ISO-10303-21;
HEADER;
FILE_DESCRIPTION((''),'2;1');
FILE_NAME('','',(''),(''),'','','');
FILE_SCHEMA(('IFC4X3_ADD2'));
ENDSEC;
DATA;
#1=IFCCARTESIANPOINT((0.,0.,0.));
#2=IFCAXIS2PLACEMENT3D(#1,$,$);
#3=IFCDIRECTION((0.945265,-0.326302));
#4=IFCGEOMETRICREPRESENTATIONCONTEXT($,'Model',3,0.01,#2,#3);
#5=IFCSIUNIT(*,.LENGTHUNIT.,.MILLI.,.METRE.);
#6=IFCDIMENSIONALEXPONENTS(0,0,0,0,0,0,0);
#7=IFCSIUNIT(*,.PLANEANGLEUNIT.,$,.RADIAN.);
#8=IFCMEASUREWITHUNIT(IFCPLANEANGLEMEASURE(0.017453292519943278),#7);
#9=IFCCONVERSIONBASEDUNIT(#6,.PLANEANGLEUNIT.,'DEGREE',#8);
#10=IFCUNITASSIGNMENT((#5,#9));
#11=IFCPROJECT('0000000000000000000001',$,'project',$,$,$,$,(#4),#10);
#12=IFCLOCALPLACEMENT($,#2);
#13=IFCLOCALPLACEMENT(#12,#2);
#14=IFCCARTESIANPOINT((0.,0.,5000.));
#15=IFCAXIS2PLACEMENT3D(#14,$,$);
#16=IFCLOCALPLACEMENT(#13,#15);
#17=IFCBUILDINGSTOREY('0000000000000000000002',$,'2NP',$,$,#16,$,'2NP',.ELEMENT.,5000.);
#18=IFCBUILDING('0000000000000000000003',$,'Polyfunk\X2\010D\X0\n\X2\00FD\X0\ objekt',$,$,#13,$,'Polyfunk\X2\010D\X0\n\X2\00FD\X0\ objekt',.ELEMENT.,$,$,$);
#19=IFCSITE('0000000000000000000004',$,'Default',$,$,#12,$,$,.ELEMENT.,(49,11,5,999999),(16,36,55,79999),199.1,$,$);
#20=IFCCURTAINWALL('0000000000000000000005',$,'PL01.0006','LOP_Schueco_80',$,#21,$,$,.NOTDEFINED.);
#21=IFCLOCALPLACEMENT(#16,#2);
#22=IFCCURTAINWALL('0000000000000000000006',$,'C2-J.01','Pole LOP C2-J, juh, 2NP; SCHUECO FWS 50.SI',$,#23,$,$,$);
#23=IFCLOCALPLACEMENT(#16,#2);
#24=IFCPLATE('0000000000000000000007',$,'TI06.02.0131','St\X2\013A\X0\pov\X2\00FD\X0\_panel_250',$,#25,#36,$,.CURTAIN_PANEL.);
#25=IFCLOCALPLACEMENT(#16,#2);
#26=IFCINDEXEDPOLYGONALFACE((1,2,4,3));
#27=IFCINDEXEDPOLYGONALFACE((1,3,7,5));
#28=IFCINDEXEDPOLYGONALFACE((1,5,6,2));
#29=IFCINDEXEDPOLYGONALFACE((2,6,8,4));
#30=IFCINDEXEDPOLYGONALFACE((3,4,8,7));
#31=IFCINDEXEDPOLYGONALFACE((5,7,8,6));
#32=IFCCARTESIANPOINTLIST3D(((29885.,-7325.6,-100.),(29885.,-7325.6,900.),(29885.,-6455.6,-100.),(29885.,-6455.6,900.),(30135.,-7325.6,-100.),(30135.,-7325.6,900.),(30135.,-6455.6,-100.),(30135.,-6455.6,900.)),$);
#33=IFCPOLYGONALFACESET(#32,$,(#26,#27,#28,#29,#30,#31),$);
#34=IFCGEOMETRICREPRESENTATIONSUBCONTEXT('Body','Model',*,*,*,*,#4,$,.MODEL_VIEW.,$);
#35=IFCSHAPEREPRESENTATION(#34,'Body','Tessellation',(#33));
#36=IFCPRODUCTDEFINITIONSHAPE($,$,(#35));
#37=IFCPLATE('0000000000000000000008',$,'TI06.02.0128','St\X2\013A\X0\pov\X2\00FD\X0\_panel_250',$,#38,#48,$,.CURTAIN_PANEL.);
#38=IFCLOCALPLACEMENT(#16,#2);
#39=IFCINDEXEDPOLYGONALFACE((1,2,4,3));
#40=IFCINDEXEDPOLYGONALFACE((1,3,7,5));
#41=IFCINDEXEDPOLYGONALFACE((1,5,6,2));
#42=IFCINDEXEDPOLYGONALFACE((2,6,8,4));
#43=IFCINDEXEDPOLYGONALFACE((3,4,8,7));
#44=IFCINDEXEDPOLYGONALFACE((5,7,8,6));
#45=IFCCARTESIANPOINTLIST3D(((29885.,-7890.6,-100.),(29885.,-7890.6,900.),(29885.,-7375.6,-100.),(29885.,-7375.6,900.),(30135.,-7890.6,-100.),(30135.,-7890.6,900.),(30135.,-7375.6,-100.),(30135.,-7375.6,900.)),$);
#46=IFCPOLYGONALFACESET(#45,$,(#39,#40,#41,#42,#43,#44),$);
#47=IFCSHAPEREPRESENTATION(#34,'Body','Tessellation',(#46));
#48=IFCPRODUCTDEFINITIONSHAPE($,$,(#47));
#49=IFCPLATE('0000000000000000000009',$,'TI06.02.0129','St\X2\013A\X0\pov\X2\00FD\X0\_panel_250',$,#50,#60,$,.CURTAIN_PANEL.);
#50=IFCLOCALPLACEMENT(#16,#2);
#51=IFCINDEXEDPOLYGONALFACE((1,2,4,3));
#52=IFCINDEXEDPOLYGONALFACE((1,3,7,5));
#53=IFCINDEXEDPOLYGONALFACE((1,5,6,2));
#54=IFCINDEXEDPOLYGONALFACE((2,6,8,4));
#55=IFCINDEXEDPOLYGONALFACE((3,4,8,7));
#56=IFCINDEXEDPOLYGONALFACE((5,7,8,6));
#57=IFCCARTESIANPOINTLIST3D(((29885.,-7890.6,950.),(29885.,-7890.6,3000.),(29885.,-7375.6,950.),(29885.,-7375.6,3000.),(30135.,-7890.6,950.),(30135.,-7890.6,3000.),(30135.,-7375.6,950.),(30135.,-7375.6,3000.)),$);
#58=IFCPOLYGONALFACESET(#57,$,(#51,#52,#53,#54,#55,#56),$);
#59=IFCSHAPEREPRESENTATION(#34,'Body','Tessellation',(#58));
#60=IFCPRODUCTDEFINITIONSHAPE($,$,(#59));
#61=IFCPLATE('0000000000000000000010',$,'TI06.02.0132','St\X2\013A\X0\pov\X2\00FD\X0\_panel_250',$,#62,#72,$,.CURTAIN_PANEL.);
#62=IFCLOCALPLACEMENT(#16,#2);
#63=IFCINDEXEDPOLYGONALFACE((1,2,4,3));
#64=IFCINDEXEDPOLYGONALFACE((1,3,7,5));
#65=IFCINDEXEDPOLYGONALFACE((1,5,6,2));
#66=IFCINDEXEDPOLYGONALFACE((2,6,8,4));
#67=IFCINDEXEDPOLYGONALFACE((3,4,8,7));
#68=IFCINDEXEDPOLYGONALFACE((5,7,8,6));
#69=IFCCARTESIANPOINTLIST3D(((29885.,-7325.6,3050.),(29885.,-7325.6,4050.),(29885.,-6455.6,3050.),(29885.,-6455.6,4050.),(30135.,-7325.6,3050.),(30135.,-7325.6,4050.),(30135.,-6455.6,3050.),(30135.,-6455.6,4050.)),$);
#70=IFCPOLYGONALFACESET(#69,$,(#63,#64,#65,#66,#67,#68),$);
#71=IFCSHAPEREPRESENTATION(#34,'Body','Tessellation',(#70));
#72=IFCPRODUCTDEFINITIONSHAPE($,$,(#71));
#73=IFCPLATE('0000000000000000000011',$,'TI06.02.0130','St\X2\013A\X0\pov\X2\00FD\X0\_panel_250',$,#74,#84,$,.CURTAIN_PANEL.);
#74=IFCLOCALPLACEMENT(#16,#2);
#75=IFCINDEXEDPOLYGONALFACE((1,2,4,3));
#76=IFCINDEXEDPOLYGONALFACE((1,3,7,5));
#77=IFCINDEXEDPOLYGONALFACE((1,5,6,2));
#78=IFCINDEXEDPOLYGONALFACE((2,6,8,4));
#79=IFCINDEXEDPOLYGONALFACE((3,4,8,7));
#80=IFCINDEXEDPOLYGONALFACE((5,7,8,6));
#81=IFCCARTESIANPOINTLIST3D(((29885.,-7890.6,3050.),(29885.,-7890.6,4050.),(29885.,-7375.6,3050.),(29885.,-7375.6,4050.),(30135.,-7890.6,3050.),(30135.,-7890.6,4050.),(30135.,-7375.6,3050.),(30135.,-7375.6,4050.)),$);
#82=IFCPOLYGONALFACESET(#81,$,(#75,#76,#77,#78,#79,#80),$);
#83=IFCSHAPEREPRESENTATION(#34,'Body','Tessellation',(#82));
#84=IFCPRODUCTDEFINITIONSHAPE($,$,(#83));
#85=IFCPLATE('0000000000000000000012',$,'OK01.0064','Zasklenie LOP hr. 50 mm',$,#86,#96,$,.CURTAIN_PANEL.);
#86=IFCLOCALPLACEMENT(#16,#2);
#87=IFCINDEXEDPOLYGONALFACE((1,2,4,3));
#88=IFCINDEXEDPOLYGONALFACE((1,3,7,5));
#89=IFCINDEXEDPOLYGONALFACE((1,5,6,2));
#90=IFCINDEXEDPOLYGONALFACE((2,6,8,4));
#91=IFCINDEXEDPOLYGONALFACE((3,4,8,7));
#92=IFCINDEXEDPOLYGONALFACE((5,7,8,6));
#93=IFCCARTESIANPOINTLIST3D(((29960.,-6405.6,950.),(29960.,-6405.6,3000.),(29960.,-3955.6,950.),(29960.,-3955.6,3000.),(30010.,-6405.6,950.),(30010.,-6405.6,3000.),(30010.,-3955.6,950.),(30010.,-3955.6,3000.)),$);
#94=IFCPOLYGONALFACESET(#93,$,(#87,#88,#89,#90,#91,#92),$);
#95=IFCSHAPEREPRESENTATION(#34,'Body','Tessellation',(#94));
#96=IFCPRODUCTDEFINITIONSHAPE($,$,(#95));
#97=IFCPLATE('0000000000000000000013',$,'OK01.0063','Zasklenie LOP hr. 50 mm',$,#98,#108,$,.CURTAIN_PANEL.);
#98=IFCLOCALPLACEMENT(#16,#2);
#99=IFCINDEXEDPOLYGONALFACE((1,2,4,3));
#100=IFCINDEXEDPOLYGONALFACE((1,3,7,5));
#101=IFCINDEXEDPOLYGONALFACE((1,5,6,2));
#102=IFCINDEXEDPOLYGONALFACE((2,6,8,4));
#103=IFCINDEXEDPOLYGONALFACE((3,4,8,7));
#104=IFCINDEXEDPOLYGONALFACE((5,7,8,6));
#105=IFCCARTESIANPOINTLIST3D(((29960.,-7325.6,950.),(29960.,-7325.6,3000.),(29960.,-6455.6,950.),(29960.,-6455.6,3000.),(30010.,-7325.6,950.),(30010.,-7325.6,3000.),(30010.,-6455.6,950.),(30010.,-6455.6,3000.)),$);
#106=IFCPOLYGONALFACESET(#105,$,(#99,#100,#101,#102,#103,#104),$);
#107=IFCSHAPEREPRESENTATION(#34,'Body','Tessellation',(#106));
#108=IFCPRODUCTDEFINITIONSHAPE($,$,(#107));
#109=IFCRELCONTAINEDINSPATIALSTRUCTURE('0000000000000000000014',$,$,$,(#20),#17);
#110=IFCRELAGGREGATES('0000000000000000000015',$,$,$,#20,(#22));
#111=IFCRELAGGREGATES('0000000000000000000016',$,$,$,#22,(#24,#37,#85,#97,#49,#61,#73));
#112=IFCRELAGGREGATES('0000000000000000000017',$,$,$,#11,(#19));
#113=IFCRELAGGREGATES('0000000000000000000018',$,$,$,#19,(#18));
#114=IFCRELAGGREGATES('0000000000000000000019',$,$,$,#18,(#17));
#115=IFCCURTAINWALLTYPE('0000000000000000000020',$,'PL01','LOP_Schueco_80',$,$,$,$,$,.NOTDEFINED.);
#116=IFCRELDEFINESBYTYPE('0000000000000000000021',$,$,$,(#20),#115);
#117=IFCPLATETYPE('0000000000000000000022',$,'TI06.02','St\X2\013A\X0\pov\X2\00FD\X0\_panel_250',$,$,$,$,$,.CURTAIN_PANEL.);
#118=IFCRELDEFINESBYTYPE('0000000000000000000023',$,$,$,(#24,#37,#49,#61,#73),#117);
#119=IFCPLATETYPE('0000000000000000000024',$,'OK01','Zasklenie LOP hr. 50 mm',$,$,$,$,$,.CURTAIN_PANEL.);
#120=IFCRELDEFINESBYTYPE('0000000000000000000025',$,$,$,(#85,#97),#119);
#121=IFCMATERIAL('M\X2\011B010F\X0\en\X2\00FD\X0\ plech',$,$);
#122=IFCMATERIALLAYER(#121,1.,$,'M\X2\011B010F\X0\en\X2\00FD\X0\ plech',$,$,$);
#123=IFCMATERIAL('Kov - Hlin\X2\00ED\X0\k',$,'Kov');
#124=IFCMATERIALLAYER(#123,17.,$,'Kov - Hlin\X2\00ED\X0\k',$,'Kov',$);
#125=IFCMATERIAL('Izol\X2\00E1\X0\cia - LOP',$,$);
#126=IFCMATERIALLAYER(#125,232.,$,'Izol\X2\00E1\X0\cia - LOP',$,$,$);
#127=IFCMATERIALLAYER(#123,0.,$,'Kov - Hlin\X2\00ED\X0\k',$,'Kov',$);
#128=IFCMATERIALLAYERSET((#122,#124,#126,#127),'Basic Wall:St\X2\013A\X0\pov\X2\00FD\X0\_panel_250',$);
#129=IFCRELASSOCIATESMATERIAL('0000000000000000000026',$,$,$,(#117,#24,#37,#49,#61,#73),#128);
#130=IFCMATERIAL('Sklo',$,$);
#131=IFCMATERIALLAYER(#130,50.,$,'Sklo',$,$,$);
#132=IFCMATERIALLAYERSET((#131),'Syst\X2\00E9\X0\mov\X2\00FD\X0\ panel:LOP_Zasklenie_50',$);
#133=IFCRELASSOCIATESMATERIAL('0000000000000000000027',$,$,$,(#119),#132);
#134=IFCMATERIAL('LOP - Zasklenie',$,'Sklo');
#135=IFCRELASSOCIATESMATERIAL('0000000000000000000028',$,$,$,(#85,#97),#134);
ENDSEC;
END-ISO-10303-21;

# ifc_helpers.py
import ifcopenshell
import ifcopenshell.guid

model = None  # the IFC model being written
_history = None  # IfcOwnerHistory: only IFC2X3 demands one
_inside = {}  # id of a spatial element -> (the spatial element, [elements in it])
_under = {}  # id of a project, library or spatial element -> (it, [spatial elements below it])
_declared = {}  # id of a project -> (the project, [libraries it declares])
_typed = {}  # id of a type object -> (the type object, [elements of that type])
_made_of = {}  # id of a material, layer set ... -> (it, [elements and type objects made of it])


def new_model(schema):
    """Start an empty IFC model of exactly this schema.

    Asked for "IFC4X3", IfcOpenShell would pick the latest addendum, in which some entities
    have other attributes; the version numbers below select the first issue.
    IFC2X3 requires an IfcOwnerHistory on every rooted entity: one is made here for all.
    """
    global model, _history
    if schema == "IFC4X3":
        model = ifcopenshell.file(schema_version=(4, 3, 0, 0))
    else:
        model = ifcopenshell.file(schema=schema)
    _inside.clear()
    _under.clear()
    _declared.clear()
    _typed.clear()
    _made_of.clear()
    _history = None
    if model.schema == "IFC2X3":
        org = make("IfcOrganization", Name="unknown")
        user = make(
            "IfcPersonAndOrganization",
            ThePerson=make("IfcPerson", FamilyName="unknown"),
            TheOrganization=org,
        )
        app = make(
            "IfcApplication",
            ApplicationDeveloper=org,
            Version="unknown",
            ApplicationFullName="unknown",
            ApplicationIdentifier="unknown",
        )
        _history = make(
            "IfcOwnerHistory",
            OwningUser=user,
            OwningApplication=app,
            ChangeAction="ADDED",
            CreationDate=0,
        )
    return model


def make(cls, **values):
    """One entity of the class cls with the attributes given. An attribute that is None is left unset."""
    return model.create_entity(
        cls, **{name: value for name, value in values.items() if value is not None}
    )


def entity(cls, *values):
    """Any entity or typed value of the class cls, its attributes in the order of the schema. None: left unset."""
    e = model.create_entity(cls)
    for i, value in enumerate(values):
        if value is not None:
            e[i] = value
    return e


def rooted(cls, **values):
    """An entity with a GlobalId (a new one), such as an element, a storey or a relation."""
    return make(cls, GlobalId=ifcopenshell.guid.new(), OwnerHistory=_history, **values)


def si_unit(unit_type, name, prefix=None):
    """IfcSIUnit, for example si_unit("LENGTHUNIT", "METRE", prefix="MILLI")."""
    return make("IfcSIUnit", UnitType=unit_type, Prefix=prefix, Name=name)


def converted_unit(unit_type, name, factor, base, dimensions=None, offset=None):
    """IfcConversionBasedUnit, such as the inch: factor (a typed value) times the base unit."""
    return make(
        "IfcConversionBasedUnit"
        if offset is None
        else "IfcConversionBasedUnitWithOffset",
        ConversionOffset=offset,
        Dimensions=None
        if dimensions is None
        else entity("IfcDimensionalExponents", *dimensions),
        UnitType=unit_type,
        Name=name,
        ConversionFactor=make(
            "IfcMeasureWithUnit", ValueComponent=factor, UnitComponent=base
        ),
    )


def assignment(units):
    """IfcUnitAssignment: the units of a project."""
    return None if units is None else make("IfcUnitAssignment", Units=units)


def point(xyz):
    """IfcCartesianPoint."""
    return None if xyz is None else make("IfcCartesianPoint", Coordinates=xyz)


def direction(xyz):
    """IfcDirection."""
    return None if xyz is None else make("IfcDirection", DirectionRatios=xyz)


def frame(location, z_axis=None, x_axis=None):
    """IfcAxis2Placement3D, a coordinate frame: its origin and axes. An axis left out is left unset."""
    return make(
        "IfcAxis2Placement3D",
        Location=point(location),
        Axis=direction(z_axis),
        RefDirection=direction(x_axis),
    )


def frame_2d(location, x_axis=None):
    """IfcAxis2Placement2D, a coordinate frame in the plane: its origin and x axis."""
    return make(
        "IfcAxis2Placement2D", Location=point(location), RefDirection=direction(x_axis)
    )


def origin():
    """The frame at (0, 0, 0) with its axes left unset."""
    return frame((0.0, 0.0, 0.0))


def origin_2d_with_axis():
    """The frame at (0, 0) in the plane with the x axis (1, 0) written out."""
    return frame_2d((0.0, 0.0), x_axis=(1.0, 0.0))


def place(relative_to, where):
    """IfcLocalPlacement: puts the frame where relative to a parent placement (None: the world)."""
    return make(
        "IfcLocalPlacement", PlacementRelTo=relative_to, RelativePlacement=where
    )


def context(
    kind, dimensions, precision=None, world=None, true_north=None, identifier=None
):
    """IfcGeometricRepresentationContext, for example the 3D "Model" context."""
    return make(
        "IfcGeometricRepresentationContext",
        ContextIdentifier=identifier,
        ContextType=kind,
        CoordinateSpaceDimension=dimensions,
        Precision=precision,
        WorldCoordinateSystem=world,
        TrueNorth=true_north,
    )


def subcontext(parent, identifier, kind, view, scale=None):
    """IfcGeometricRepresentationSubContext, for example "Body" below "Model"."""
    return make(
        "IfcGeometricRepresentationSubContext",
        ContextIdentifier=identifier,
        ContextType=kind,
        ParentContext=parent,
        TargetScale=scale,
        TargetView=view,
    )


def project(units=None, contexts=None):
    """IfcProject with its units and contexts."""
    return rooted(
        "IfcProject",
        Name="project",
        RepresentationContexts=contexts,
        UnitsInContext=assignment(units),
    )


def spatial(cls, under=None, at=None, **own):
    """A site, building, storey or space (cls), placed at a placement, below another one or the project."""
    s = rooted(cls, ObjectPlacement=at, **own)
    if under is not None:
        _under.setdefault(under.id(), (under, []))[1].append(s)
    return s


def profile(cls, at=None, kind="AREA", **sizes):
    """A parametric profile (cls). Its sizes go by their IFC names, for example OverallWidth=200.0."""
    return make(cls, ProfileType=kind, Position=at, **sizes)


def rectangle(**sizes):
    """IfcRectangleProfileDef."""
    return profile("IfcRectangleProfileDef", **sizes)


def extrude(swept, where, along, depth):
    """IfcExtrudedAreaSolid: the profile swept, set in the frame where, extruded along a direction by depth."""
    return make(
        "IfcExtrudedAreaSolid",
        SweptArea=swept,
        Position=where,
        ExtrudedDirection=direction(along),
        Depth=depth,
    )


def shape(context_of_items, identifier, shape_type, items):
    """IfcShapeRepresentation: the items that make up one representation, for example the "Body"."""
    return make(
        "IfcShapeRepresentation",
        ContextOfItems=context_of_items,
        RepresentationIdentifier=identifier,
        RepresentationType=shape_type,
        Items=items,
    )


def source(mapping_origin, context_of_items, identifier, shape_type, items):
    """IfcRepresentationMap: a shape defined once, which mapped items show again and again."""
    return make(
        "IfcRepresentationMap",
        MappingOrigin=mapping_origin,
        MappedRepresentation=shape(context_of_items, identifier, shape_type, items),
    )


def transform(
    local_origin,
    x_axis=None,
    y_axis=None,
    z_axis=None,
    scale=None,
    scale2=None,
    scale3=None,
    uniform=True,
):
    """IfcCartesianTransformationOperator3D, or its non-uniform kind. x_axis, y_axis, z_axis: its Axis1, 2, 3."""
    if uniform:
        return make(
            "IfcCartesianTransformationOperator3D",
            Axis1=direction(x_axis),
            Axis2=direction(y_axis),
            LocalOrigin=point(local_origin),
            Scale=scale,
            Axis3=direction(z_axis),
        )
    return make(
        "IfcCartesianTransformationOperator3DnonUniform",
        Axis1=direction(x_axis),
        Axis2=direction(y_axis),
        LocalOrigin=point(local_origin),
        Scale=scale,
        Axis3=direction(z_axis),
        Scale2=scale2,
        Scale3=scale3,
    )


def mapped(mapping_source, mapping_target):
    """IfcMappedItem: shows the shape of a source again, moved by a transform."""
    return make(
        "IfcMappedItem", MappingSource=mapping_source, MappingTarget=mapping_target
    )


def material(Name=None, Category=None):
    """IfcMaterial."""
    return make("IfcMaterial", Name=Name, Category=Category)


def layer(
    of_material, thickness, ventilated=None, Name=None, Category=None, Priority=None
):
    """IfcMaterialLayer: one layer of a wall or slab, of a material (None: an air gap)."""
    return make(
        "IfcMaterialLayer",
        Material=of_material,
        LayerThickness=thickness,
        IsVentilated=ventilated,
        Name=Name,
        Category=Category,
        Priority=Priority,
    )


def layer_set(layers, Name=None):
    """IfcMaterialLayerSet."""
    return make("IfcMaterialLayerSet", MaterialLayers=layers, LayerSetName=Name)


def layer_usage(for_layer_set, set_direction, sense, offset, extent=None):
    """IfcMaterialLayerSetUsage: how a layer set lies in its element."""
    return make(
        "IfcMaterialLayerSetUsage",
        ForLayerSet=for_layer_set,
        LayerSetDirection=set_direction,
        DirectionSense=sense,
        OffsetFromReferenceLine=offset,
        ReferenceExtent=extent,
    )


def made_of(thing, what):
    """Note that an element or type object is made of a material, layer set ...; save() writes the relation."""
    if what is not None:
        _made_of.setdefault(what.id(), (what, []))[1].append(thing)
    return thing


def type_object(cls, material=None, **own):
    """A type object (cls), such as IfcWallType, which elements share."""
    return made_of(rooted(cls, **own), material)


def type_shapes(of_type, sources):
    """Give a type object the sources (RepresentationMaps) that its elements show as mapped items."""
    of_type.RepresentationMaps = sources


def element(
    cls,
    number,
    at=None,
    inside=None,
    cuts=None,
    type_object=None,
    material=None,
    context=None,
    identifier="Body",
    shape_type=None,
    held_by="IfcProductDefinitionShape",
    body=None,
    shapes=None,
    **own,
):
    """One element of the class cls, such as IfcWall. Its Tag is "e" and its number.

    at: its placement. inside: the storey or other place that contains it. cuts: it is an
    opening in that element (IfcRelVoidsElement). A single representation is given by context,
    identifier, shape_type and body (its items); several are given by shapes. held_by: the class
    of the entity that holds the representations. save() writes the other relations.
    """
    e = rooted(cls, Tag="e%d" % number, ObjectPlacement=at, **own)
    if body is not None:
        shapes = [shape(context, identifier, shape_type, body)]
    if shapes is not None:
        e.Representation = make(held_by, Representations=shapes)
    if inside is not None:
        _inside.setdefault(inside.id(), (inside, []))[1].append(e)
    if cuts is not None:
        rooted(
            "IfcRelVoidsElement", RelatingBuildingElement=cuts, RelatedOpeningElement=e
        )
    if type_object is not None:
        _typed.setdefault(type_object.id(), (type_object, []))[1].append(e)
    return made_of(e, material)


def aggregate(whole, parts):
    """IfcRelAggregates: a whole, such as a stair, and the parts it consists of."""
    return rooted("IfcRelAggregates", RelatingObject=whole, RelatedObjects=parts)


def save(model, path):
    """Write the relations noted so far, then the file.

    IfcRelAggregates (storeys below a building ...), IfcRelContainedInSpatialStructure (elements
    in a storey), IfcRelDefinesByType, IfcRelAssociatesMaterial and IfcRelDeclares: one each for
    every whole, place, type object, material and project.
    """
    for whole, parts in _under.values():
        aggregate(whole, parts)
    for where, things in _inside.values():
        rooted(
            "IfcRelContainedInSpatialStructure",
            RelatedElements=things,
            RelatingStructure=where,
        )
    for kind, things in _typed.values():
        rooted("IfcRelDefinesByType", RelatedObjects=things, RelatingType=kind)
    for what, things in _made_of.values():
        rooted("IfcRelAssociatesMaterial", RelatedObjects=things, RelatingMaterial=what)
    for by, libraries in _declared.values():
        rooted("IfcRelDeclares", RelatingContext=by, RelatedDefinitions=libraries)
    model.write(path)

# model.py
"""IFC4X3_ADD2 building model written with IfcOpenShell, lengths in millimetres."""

from ifc_helpers import new_model, entity, si_unit, converted_unit, direction, frame, frame_2d, origin, origin_2d_with_axis, place, context, subcontext, project, spatial, rectangle, extrude, source, transform, mapped, material, layer, layer_set, layer_usage, type_object, type_shapes, element, aggregate, save


model = new_model("IFC4X3_ADD2")

# Units and contexts
model_context = context("Model", 3, precision=0.01, world=origin(), true_north=direction((0.945265, -0.326302)))
body_context = subcontext(model_context, "Body", "Model", "MODEL_VIEW")
ifc_project = project(units=[si_unit("LENGTHUNIT", "METRE", prefix="MILLI"), converted_unit("PLANEANGLEUNIT", "DEGREE", entity("IfcPlaneAngleMeasure", 0.017453292519943278), si_unit("PLANEANGLEUNIT", "RADIAN"), dimensions=[0, 0, 0, 0, 0, 0, 0])], contexts=[model_context])

# Site, building, storey
site_placement = place(None, origin())
site = spatial("IfcSite", under=ifc_project, at=site_placement, Name="Default", CompositionType="ELEMENT", RefLatitude=(49, 11, 5, 999999), RefLongitude=(16, 36, 55, 79999), RefElevation=199.1)
building_placement = place(site_placement, origin())
building = spatial("IfcBuilding", under=site, at=building_placement, Name="Polyfunkčný objekt", LongName="Polyfunkčný objekt", CompositionType="ELEMENT")
storey_placement = place(building_placement, frame((0.0, 0.0, 5000.0)))
storey = spatial("IfcBuildingStorey", under=building, at=storey_placement, Name="2NP", LongName="2NP", CompositionType="ELEMENT", Elevation=5000.0)

# Curtain walls, plates
curtain_wall_type = type_object("IfcCurtainWallType", Name="PL01", Description="LOP_Schueco_80", PredefinedType="NOTDEFINED")
curtain_wall_1_placement = place(storey_placement, frame((0.0, 0.0, -5000.0)))
curtain_wall_1 = element("IfcCurtainWall", 1, at=curtain_wall_1_placement, inside=storey, type_object=curtain_wall_type, Name="PL01.0006", Description="LOP_Schueco_80", PredefinedType="NOTDEFINED")
curtain_wall_2 = element("IfcCurtainWall", 2, Name="C2-J.01", Description="Pole LOP C2-J, juh, 2NP; SCHUECO FWS 50.SI")
aggregate(curtain_wall_1, [curtain_wall_2])
ifc_material_1 = material(Name="Měďený plech")
ifc_layer_1 = layer(ifc_material_1, 1.0, Name="Měďený plech")
ifc_material_2 = material(Name="Kov - Hliník", Category="Kov")
ifc_layer_2 = layer(ifc_material_2, 17.0, Name="Kov - Hliník", Category="Kov")
ifc_material_3 = material(Name="Izolácia - LOP")
ifc_layer_3 = layer(ifc_material_3, 232.0, Name="Izolácia - LOP")
ifc_layer_4 = layer(ifc_material_2, 0.0, Name="Kov - Hliník", Category="Kov")
ifc_layer_set_1 = layer_set([ifc_layer_1, ifc_layer_2, ifc_layer_3, ifc_layer_4], Name="Basic Wall:Stĺpový_panel_250")
ifc_layer_usage_1 = layer_usage(ifc_layer_set_1, "AXIS2", "POSITIVE", -125.0)
plate_type_1 = type_object("IfcPlateType", Name="TI06.02", Description="Stĺpový_panel_250", PredefinedType="CURTAIN_PANEL", material=ifc_layer_set_1)
plate_1_placement = place(storey_placement, frame((30010.0, -6455.6, -100.0), z_axis=(0.0, 0.0, 1.0), x_axis=(0.0, -1.0, 0.0)))
plate_1 = element("IfcPlate", 3, at=plate_1_placement, type_object=plate_type_1, material=ifc_layer_usage_1, Name="TI06.02.0131", Description="Stĺpový_panel_250", PredefinedType="CURTAIN_PANEL", context=body_context, shape_type="SweptSolid", body=[
    extrude(rectangle(XDim=250.0, YDim=870.0, at=frame_2d((0.0, 0.0), x_axis=(1.0, 0.0))), frame((435.0, 0.0, 0.0), z_axis=(0.0, 0.0, 1.0), x_axis=(0.0, 1.0, 0.0)), (0.0, 0.0, 1.0), 1000.0),
])
ifc_layer_usage_2 = layer_usage(ifc_layer_set_1, "AXIS2", "POSITIVE", -125.0)
plate_2_placement = place(storey_placement, frame((30010.0, -7375.6, -100.0), z_axis=(0.0, 0.0, 1.0), x_axis=(0.0, -1.0, 0.0)))
plate_2 = element("IfcPlate", 4, at=plate_2_placement, type_object=plate_type_1, material=ifc_layer_usage_2, Name="TI06.02.0128", Description="Stĺpový_panel_250", PredefinedType="CURTAIN_PANEL", context=body_context, shape_type="SweptSolid", body=[
    extrude(rectangle(XDim=250.0, YDim=515.0, at=frame_2d((0.0, 0.0), x_axis=(1.0, 0.0))), frame((257.5, 0.0, 0.0), z_axis=(0.0, 0.0, 1.0), x_axis=(0.0, 1.0, 0.0)), (0.0, 0.0, 1.0), 1000.0),
])
ifc_layer_usage_3 = layer_usage(ifc_layer_set_1, "AXIS2", "POSITIVE", -125.0)
plate_3_placement = place(storey_placement, frame((30010.0, -7375.6, 950.0), z_axis=(0.0, 0.0, 1.0), x_axis=(0.0, -1.0, 0.0)))
plate_3 = element("IfcPlate", 5, at=plate_3_placement, type_object=plate_type_1, material=ifc_layer_usage_3, Name="TI06.02.0129", Description="Stĺpový_panel_250", PredefinedType="CURTAIN_PANEL", context=body_context, shape_type="SweptSolid", body=[
    extrude(rectangle(XDim=250.0, YDim=515.0, at=frame_2d((0.0, 0.0), x_axis=(1.0, 0.0))), frame((257.5, 0.0, 0.0), z_axis=(0.0, 0.0, 1.0), x_axis=(0.0, 1.0, 0.0)), (0.0, 0.0, 1.0), 2050.0),
])
ifc_layer_usage_4 = layer_usage(ifc_layer_set_1, "AXIS2", "POSITIVE", -125.0)
plate_4_placement = place(storey_placement, frame((30010.0, -6455.6, 3050.0), z_axis=(0.0, 0.0, 1.0), x_axis=(0.0, -1.0, 0.0)))
plate_4 = element("IfcPlate", 6, at=plate_4_placement, type_object=plate_type_1, material=ifc_layer_usage_4, Name="TI06.02.0132", Description="Stĺpový_panel_250", PredefinedType="CURTAIN_PANEL", context=body_context, shape_type="SweptSolid", body=[
    extrude(rectangle(XDim=250.0, YDim=870.0, at=frame_2d((0.0, 0.0), x_axis=(1.0, 0.0))), frame((435.0, 0.0, 0.0), z_axis=(0.0, 0.0, 1.0), x_axis=(0.0, 1.0, 0.0)), (0.0, 0.0, 1.0), 1000.0),
])
ifc_layer_usage_5 = layer_usage(ifc_layer_set_1, "AXIS2", "POSITIVE", -125.0)
plate_5_placement = place(storey_placement, frame((30010.0, -7375.6, 3050.0), z_axis=(0.0, 0.0, 1.0), x_axis=(0.0, -1.0, 0.0)))
plate_5 = element("IfcPlate", 7, at=plate_5_placement, type_object=plate_type_1, material=ifc_layer_usage_5, Name="TI06.02.0130", Description="Stĺpový_panel_250", PredefinedType="CURTAIN_PANEL", context=body_context, shape_type="SweptSolid", body=[
    extrude(rectangle(XDim=250.0, YDim=515.0, at=frame_2d((0.0, 0.0), x_axis=(1.0, 0.0))), frame((257.5, 0.0, 0.0), z_axis=(0.0, 0.0, 1.0), x_axis=(0.0, 1.0, 0.0)), (0.0, 0.0, 1.0), 1000.0),
])
ifc_material_4 = material(Name="LOP - Zasklenie", Category="Sklo")
ifc_material_5 = material(Name="Sklo")
ifc_layer_5 = layer(ifc_material_5, 50.0, Name="Sklo")
ifc_layer_set_2 = layer_set([ifc_layer_5], Name="Systémový panel:LOP_Zasklenie_50")
plate_type_2 = type_object("IfcPlateType", Name="OK01", Description="Zasklenie LOP hr. 50 mm", PredefinedType="CURTAIN_PANEL", material=ifc_layer_set_2)
shared_shape_1 = source(origin(), body_context, "Body", "SweptSolid", [
    extrude(rectangle(XDim=50.0, YDim=2450.0, at=origin_2d_with_axis()), frame((0.0, -25.0, 0.0), z_axis=(0.0, 0.0, 1.0), x_axis=(0.0, 1.0, 0.0)), (0.0, 0.0, 1.0), 2050.0),
])
plate_6_placement = place(curtain_wall_1_placement, frame((30010.0, -5180.6, 5950.0), z_axis=(0.0, 0.0, 1.0), x_axis=(0.0, -1.0, 0.0)))
plate_6 = element("IfcPlate", 8, at=plate_6_placement, type_object=plate_type_2, material=ifc_material_4, Name="OK01.0064", Description="Zasklenie LOP hr. 50 mm", PredefinedType="CURTAIN_PANEL", context=body_context, shape_type="MappedRepresentation", body=[
    mapped(shared_shape_1, transform((0.0, 0.0, 0.0), scale=1.0)),
])
shared_shape_2 = source(origin(), body_context, "Body", "SweptSolid", [
    extrude(rectangle(XDim=50.0, YDim=870.0, at=origin_2d_with_axis()), frame((0.0, -25.0, 0.0), z_axis=(0.0, 0.0, 1.0), x_axis=(0.0, 1.0, 0.0)), (0.0, 0.0, 1.0), 2050.0),
])
type_shapes(plate_type_2, [shared_shape_1, shared_shape_2])
plate_7_placement = place(curtain_wall_1_placement, frame((30010.0, -6890.6, 5950.0), z_axis=(0.0, 0.0, 1.0), x_axis=(0.0, -1.0, 0.0)))
plate_7 = element("IfcPlate", 9, at=plate_7_placement, type_object=plate_type_2, material=ifc_material_4, Name="OK01.0063", Description="Zasklenie LOP hr. 50 mm", PredefinedType="CURTAIN_PANEL", context=body_context, shape_type="MappedRepresentation", body=[
    mapped(shared_shape_2, transform((0.0, 0.0, 0.0), scale=1.0)),
])
aggregate(curtain_wall_2, [plate_1, plate_2, plate_6, plate_7, plate_3, plate_4, plate_5])

save(model, "model.ifc")
